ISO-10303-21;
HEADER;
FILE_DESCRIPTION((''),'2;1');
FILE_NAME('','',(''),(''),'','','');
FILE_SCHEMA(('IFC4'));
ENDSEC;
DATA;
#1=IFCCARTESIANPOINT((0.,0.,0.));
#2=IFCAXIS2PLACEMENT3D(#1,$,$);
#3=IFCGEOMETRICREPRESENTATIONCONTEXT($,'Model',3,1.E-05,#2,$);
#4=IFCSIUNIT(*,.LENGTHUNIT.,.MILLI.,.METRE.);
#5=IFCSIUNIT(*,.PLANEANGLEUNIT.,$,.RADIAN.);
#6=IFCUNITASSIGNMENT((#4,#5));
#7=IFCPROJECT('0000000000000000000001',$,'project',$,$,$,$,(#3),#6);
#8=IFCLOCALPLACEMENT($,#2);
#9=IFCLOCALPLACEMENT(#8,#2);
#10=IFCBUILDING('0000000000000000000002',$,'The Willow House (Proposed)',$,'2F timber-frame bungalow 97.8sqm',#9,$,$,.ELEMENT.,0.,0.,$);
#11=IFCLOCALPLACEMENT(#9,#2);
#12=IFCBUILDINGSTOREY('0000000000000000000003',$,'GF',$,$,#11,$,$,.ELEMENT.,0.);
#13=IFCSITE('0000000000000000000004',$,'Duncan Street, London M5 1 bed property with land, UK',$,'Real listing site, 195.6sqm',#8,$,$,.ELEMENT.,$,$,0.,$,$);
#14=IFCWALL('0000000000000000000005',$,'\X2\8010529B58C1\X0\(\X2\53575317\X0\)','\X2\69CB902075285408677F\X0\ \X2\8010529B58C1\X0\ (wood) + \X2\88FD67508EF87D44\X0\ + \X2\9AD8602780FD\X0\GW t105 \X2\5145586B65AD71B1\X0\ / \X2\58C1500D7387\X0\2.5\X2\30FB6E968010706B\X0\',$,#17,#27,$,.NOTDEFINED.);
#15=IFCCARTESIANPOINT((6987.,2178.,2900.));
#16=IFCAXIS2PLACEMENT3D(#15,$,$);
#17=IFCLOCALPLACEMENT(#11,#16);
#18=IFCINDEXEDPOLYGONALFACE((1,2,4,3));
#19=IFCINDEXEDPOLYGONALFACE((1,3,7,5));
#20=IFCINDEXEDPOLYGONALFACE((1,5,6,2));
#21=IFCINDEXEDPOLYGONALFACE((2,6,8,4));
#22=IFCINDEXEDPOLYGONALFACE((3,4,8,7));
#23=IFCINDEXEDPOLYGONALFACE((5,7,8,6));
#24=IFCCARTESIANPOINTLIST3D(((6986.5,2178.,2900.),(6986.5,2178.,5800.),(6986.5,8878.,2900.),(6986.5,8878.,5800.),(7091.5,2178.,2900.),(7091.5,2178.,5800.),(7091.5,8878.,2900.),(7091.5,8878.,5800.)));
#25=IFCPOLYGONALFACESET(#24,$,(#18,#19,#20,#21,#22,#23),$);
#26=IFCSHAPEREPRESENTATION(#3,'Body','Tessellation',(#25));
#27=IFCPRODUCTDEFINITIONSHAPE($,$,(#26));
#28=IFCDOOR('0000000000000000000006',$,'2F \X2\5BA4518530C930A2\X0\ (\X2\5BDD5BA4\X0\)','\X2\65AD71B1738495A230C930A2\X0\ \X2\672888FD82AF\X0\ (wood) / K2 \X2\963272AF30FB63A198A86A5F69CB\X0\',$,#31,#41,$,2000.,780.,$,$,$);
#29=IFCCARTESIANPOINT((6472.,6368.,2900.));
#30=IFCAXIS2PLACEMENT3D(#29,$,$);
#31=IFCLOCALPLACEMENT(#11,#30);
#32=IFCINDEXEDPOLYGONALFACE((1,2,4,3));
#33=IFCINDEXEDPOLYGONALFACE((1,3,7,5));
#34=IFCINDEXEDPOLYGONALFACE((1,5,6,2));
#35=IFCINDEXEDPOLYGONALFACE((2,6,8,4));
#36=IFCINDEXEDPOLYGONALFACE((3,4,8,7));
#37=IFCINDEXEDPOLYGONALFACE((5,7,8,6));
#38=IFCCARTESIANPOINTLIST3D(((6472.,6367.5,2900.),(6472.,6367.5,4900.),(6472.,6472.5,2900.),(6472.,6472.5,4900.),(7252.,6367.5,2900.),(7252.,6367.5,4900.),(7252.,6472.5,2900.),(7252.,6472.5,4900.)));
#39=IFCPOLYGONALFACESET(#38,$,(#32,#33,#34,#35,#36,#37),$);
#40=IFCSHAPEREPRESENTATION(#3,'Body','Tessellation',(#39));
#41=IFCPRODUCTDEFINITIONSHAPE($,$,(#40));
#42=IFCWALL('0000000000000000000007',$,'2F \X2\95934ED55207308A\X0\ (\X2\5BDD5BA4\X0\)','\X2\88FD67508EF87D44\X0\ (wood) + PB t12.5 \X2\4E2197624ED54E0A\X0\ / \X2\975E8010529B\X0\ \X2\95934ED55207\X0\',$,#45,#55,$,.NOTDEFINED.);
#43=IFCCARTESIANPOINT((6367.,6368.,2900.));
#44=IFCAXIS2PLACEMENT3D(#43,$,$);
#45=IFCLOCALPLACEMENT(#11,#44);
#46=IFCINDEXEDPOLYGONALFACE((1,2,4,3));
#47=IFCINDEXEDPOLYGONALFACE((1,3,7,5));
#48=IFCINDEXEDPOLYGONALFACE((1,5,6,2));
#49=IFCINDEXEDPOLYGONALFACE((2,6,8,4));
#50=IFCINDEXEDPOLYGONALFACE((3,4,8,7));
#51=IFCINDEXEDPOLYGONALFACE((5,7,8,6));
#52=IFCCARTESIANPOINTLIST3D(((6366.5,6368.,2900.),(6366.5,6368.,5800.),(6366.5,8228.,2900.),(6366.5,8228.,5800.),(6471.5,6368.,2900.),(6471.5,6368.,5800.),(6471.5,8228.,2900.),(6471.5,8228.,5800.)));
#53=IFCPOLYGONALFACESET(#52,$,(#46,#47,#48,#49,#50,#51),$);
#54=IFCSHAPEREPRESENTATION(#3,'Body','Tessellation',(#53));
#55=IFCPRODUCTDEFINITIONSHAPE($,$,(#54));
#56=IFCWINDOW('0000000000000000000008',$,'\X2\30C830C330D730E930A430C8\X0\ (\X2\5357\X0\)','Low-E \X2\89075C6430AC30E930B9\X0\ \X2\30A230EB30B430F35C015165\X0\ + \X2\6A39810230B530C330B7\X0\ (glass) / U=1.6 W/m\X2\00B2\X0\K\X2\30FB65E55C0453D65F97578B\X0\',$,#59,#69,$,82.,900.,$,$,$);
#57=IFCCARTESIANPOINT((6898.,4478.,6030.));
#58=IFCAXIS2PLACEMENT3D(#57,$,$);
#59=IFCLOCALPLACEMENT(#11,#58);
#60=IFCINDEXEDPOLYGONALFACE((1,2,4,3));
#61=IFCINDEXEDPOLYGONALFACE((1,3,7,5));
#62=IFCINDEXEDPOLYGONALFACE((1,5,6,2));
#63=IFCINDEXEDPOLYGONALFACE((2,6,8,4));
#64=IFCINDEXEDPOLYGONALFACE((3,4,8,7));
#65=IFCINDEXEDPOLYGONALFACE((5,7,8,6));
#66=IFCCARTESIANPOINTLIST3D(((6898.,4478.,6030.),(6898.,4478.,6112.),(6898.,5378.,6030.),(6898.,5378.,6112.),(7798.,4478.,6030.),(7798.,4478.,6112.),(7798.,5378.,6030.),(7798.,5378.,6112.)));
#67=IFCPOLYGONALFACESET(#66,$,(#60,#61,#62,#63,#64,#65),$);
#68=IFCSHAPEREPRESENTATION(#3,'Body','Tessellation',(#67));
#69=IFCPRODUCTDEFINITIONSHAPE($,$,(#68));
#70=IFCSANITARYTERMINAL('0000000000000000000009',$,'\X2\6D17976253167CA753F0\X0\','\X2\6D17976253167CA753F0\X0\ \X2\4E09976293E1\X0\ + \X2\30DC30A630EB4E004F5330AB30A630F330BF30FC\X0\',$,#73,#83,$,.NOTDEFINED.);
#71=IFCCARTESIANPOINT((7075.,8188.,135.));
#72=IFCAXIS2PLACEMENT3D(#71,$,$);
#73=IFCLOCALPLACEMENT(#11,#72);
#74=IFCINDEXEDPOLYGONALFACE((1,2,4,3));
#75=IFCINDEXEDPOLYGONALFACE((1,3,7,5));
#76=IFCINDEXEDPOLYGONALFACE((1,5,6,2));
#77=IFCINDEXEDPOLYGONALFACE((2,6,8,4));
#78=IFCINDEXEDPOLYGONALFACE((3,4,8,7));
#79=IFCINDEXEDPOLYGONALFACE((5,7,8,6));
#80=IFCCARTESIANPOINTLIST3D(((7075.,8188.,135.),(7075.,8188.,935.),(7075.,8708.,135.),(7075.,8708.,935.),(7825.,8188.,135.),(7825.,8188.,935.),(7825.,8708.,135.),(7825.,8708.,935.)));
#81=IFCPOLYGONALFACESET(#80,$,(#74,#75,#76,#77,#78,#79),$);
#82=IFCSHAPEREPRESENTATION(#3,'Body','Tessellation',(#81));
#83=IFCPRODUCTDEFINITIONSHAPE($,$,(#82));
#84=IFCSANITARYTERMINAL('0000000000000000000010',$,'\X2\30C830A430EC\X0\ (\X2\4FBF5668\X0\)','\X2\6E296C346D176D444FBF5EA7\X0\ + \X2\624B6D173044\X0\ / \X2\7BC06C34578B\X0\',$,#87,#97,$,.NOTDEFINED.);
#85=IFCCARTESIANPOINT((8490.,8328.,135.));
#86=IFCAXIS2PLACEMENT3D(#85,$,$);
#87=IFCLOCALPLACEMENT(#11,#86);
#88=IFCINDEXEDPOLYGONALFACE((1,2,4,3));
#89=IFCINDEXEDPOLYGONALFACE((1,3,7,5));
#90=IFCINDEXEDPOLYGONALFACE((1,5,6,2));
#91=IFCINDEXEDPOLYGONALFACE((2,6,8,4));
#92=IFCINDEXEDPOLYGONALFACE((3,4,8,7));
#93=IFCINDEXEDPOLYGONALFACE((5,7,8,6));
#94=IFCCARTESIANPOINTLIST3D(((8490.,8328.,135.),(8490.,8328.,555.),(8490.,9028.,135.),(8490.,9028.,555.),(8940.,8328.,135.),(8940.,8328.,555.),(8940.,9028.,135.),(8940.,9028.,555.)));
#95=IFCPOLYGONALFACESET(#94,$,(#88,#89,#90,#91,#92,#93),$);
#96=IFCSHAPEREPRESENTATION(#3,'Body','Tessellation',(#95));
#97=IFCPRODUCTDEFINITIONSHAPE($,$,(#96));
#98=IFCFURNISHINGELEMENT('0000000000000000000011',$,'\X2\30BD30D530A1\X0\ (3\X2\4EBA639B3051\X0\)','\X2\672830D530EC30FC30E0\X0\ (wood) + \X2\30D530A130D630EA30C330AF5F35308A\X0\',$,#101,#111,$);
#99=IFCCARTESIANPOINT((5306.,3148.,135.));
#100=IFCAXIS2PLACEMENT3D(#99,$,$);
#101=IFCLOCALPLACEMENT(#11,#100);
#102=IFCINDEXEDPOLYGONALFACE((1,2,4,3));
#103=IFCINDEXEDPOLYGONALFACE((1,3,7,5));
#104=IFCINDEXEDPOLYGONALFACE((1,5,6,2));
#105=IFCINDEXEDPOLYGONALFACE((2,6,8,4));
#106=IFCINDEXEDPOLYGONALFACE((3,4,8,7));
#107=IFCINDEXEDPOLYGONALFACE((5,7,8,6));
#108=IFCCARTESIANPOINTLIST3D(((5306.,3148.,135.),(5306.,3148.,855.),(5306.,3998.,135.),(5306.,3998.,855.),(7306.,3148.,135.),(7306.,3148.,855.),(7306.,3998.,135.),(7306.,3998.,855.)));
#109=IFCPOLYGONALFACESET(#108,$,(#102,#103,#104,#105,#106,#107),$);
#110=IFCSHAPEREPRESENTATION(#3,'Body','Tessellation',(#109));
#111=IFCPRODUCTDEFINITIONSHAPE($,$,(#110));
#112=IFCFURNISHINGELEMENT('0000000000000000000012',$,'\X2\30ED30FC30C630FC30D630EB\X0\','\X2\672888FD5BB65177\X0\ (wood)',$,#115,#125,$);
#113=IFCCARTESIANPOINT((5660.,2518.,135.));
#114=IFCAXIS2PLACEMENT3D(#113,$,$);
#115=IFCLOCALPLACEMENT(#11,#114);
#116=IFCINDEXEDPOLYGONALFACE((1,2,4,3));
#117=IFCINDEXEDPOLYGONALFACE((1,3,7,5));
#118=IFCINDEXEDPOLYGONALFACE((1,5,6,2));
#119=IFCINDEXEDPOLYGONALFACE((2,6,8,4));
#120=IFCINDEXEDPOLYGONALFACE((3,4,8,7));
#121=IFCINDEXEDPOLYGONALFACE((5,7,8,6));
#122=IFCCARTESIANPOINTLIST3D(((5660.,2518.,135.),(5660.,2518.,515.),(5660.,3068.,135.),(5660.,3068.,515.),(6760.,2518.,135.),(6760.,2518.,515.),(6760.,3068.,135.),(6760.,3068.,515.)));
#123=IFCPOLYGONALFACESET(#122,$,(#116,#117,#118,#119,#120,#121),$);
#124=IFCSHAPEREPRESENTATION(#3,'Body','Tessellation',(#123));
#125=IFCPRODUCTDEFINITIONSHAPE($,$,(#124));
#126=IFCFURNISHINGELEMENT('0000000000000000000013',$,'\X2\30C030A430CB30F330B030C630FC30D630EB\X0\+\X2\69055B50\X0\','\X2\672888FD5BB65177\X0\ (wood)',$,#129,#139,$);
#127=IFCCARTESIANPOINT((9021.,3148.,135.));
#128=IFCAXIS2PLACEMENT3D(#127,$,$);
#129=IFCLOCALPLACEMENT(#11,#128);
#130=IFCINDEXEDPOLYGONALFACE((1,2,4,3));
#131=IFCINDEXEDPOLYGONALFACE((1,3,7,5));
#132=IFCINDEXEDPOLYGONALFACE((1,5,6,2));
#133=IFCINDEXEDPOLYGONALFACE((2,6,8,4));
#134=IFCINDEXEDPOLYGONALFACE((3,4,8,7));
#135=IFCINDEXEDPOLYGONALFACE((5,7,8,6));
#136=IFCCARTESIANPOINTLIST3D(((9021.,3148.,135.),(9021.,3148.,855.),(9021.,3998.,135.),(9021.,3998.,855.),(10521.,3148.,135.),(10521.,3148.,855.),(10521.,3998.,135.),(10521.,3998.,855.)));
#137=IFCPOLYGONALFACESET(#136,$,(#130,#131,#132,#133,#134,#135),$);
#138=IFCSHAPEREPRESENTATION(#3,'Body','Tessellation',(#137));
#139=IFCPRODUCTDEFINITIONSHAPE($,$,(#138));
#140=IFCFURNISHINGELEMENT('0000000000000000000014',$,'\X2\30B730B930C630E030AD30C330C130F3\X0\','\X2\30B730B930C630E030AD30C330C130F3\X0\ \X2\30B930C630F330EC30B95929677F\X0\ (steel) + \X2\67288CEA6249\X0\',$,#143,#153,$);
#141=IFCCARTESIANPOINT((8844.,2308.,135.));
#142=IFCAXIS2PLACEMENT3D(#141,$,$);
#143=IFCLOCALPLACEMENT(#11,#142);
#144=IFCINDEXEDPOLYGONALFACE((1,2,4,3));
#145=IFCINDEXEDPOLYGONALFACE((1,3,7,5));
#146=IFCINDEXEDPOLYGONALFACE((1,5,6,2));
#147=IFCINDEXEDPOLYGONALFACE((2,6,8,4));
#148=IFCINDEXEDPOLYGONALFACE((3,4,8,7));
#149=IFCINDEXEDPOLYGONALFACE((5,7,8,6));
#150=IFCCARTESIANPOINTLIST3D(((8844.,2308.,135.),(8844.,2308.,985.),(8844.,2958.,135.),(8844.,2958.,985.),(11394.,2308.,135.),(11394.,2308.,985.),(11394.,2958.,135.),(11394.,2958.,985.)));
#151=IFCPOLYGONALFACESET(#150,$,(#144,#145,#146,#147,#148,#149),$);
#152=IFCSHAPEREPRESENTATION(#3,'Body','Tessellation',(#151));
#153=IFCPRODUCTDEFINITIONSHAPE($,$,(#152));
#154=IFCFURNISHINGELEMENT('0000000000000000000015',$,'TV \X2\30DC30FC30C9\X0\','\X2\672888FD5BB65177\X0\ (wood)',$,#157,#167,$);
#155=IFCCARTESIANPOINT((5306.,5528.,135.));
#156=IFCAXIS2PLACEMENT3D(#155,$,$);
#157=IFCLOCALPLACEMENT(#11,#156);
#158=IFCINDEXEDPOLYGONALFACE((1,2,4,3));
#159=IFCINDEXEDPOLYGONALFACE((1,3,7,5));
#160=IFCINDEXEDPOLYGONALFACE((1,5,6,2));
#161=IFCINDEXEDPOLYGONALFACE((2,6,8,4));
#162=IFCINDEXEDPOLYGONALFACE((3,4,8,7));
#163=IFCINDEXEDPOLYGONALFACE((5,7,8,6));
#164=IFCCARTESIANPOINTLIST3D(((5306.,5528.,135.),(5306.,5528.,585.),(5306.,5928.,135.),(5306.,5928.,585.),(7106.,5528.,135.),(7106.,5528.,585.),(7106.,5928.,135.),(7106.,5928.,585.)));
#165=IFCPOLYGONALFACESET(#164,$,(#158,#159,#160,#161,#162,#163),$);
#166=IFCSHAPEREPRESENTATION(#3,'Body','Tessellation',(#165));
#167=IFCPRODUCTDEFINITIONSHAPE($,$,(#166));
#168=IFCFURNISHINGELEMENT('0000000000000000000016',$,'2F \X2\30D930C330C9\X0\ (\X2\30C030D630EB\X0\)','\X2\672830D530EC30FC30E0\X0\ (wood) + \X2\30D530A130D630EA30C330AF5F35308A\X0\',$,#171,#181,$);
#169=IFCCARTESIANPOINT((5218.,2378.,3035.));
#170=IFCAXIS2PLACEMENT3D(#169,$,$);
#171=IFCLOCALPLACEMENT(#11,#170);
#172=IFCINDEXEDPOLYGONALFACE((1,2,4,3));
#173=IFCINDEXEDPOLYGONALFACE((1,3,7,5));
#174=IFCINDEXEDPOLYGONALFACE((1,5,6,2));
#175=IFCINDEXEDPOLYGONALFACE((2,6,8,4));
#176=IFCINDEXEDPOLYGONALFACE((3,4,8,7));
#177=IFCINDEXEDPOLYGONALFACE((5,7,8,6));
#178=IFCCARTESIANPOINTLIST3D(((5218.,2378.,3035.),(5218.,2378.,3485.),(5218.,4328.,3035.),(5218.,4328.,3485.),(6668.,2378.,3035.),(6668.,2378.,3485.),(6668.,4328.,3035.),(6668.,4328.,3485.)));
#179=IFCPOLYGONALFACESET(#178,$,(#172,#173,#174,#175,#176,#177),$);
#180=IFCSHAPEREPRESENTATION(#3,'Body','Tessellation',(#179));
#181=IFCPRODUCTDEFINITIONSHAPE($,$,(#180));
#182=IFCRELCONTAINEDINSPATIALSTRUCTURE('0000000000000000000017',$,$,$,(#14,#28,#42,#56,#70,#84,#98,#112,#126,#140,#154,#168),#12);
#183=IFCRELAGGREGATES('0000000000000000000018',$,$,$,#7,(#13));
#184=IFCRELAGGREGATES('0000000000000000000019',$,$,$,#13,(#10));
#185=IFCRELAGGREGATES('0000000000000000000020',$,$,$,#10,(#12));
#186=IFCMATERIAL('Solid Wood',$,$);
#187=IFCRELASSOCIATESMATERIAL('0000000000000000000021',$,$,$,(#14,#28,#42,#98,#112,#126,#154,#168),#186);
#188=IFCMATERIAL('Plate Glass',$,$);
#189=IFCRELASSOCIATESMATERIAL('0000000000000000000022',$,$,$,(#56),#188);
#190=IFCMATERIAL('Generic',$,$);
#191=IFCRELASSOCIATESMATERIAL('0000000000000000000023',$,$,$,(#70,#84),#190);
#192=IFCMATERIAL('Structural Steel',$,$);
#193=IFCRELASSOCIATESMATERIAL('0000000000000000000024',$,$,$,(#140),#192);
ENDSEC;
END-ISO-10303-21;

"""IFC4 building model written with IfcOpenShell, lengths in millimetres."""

from ifc_helpers import new_model, si_unit, frame, frame_2d, origin, place, context, project, spatial, rectangle, extrude, material, element, fill, save


model = new_model("IFC4")

# Units and contexts
model_context = context("Model", 3, precision=1e-05, world=origin())
ifc_project = project(units=[si_unit("LENGTHUNIT", "METRE", prefix="MILLI"), si_unit("PLANEANGLEUNIT", "RADIAN")], contexts=[model_context])

# Site, building, storey
site_placement = place(None, origin())
site = spatial("IfcSite", under=ifc_project, at=site_placement, Name="Duncan Street, London M5 1 bed property with land, UK", ObjectType="Real listing site, 195.6sqm", CompositionType="ELEMENT", RefElevation=0.0)
building_placement = place(site_placement, origin())
building = spatial("IfcBuilding", under=site, at=building_placement, Name="The Willow House (Proposed)", ObjectType="2F timber-frame bungalow 97.8sqm", CompositionType="ELEMENT", ElevationOfRefHeight=0.0, ElevationOfTerrain=0.0)
storey_placement = place(building_placement, origin())
storey = spatial("IfcBuildingStorey", under=building, at=storey_placement, Name="GF", CompositionType="ELEMENT", Elevation=0.0)

# Shared definitions
ifc_material_1 = material(Name="Solid Wood")

# Wall, opening, door
wall_1_placement = place(storey_placement, frame((6987.0, 2178.0, 2900.0)))
wall_1 = element("IfcWall", 1, at=wall_1_placement, inside=storey, material=ifc_material_1, Name="耐力壁(南北)", Description="構造用合板 耐力壁 (wood) + 製材軸組 + 高性能GW t105 充填断熱 / 壁倍率2.5・準耐火", PredefinedType="NOTDEFINED", context=model_context, shape_type="SweptSolid", body=[
    extrude(rectangle(XDim=105.0, YDim=6700.0, at=frame_2d((52.0, 3350.0))), frame((6987.0, 2178.0, 2900.0)), (0.0, 0.0, 1.0), 2900.0),
])
opening_1_placement = place(storey_placement, frame((6472.0, 6368.0, 2900.0)))
opening_1 = element("IfcOpeningElement", 2, at=opening_1_placement, cuts=wall_1, PredefinedType="NOTDEFINED", context=model_context, shape_type="SweptSolid", body=[
    extrude(rectangle(XDim=780.0, YDim=105.0, at=frame_2d((390.0, 52.0))), frame((6472.0, 6368.0, 2900.0)), (0.0, 0.0, 1.0), 2000.0),
])
door_1_placement = place(storey_placement, frame((6472.0, 6368.0, 2900.0)))
door_1 = element("IfcDoor", 3, at=door_1_placement, inside=storey, material=ifc_material_1, Name="2F 室内ドア (寝室)", Description="断熱玄関ドア 木製芯 (wood) / K2 防犯・採風機構", OverallHeight=2000.0, OverallWidth=780.0, context=model_context, shape_type="SweptSolid", body=[
    extrude(rectangle(XDim=780.0, YDim=105.0, at=frame_2d((390.0, 52.0))), frame((6472.0, 6368.0, 2900.0)), (0.0, 0.0, 1.0), 2000.0),
])
fill(opening_1, door_1)

# Wall
wall_2_placement = place(storey_placement, frame((6367.0, 6368.0, 2900.0)))
element("IfcWall", 4, at=wall_2_placement, inside=storey, material=ifc_material_1, Name="2F 間仕切り (寝室)", Description="製材軸組 (wood) + PB t12.5 両面仕上 / 非耐力 間仕切", PredefinedType="NOTDEFINED", context=model_context, shape_type="SweptSolid", body=[
    extrude(rectangle(XDim=105.0, YDim=1860.0, at=frame_2d((52.0, 930.0))), frame((6367.0, 6368.0, 2900.0)), (0.0, 0.0, 1.0), 2900.0),
])

# Window
ifc_material_2 = material(Name="Plate Glass")
window_placement = place(storey_placement, frame((6898.0, 4478.0, 6030.0)))
element("IfcWindow", 5, at=window_placement, inside=storey, material=ifc_material_2, Name="トップライト (南)", Description="Low-E 複層ガラス アルゴン封入 + 樹脂サッシ (glass) / U=1.6 W/m²K・日射取得型", OverallHeight=82.0, OverallWidth=900.0, context=model_context, shape_type="SweptSolid", body=[
    extrude(rectangle(XDim=900.0, YDim=900.0, at=frame_2d((450.0, 450.0))), frame((6898.0, 4478.0, 6030.0)), (0.0, 0.0, 1.0), 82.0),
])

# Sanitary terminals
ifc_material_3 = material(Name="Generic")
sanitary_terminal_1_placement = place(storey_placement, frame((7075.0, 8188.0, 135.0)))
element("IfcSanitaryTerminal", 6, at=sanitary_terminal_1_placement, inside=storey, material=ifc_material_3, Name="洗面化粧台", Description="洗面化粧台 三面鏡 + ボウル一体カウンター", PredefinedType="NOTDEFINED", context=model_context, shape_type="SweptSolid", body=[
    extrude(rectangle(XDim=750.0, YDim=520.0, at=frame_2d((375.0, 260.0))), frame((7075.0, 8188.0, 135.0)), (0.0, 0.0, 1.0), 800.0),
])
sanitary_terminal_2_placement = place(storey_placement, frame((8490.0, 8328.0, 135.0)))
element("IfcSanitaryTerminal", 7, at=sanitary_terminal_2_placement, inside=storey, material=ifc_material_3, Name="トイレ (便器)", Description="温水洗浄便座 + 手洗い / 節水型", PredefinedType="NOTDEFINED", context=model_context, shape_type="SweptSolid", body=[
    extrude(rectangle(XDim=450.0, YDim=700.0, at=frame_2d((225.0, 350.0))), frame((8490.0, 8328.0, 135.0)), (0.0, 0.0, 1.0), 420.0),
])

# Furnishing elements
furnishing_1_placement = place(storey_placement, frame((5306.0, 3148.0, 135.0)))
element("IfcFurnishingElement", 8, at=furnishing_1_placement, inside=storey, material=ifc_material_1, Name="ソファ (3人掛け)", Description="木フレーム (wood) + ファブリック張り", context=model_context, shape_type="SweptSolid", body=[
    extrude(rectangle(XDim=2000.0, YDim=850.0, at=frame_2d((1000.0, 425.0))), frame((5306.0, 3148.0, 135.0)), (0.0, 0.0, 1.0), 720.0),
])
furnishing_2_placement = place(storey_placement, frame((5660.0, 2518.0, 135.0)))
element("IfcFurnishingElement", 9, at=furnishing_2_placement, inside=storey, material=ifc_material_1, Name="ローテーブル", Description="木製家具 (wood)", context=model_context, shape_type="SweptSolid", body=[
    extrude(rectangle(XDim=1100.0, YDim=550.0, at=frame_2d((550.0, 275.0))), frame((5660.0, 2518.0, 135.0)), (0.0, 0.0, 1.0), 380.0),
])
furnishing_3_placement = place(storey_placement, frame((9021.0, 3148.0, 135.0)))
element("IfcFurnishingElement", 10, at=furnishing_3_placement, inside=storey, material=ifc_material_1, Name="ダイニングテーブル+椅子", Description="木製家具 (wood)", context=model_context, shape_type="SweptSolid", body=[
    extrude(rectangle(XDim=1500.0, YDim=850.0, at=frame_2d((750.0, 425.0))), frame((9021.0, 3148.0, 135.0)), (0.0, 0.0, 1.0), 720.0),
])
ifc_material_4 = material(Name="Structural Steel")
furnishing_4_placement = place(storey_placement, frame((8844.0, 2308.0, 135.0)))
element("IfcFurnishingElement", 11, at=furnishing_4_placement, inside=storey, material=ifc_material_4, Name="システムキッチン", Description="システムキッチン ステンレス天板 (steel) + 木質扉", context=model_context, shape_type="SweptSolid", body=[
    extrude(rectangle(XDim=2550.0, YDim=650.0, at=frame_2d((1275.0, 325.0))), frame((8844.0, 2308.0, 135.0)), (0.0, 0.0, 1.0), 850.0),
])
furnishing_5_placement = place(storey_placement, frame((5306.0, 5528.0, 135.0)))
element("IfcFurnishingElement", 12, at=furnishing_5_placement, inside=storey, material=ifc_material_1, Name="TV ボード", Description="木製家具 (wood)", context=model_context, shape_type="SweptSolid", body=[
    extrude(rectangle(XDim=1800.0, YDim=400.0, at=frame_2d((900.0, 200.0))), frame((5306.0, 5528.0, 135.0)), (0.0, 0.0, 1.0), 450.0),
])
furnishing_6_placement = place(storey_placement, frame((5218.0, 2378.0, 3035.0)))
element("IfcFurnishingElement", 13, at=furnishing_6_placement, inside=storey, material=ifc_material_1, Name="2F ベッド (ダブル)", Description="木フレーム (wood) + ファブリック張り", context=model_context, shape_type="SweptSolid", body=[
    extrude(rectangle(XDim=1450.0, YDim=1950.0, at=frame_2d((725.0, 975.0))), frame((5218.0, 2378.0, 3035.0)), (0.0, 0.0, 1.0), 450.0),
])

save(model, "model.ifc")
